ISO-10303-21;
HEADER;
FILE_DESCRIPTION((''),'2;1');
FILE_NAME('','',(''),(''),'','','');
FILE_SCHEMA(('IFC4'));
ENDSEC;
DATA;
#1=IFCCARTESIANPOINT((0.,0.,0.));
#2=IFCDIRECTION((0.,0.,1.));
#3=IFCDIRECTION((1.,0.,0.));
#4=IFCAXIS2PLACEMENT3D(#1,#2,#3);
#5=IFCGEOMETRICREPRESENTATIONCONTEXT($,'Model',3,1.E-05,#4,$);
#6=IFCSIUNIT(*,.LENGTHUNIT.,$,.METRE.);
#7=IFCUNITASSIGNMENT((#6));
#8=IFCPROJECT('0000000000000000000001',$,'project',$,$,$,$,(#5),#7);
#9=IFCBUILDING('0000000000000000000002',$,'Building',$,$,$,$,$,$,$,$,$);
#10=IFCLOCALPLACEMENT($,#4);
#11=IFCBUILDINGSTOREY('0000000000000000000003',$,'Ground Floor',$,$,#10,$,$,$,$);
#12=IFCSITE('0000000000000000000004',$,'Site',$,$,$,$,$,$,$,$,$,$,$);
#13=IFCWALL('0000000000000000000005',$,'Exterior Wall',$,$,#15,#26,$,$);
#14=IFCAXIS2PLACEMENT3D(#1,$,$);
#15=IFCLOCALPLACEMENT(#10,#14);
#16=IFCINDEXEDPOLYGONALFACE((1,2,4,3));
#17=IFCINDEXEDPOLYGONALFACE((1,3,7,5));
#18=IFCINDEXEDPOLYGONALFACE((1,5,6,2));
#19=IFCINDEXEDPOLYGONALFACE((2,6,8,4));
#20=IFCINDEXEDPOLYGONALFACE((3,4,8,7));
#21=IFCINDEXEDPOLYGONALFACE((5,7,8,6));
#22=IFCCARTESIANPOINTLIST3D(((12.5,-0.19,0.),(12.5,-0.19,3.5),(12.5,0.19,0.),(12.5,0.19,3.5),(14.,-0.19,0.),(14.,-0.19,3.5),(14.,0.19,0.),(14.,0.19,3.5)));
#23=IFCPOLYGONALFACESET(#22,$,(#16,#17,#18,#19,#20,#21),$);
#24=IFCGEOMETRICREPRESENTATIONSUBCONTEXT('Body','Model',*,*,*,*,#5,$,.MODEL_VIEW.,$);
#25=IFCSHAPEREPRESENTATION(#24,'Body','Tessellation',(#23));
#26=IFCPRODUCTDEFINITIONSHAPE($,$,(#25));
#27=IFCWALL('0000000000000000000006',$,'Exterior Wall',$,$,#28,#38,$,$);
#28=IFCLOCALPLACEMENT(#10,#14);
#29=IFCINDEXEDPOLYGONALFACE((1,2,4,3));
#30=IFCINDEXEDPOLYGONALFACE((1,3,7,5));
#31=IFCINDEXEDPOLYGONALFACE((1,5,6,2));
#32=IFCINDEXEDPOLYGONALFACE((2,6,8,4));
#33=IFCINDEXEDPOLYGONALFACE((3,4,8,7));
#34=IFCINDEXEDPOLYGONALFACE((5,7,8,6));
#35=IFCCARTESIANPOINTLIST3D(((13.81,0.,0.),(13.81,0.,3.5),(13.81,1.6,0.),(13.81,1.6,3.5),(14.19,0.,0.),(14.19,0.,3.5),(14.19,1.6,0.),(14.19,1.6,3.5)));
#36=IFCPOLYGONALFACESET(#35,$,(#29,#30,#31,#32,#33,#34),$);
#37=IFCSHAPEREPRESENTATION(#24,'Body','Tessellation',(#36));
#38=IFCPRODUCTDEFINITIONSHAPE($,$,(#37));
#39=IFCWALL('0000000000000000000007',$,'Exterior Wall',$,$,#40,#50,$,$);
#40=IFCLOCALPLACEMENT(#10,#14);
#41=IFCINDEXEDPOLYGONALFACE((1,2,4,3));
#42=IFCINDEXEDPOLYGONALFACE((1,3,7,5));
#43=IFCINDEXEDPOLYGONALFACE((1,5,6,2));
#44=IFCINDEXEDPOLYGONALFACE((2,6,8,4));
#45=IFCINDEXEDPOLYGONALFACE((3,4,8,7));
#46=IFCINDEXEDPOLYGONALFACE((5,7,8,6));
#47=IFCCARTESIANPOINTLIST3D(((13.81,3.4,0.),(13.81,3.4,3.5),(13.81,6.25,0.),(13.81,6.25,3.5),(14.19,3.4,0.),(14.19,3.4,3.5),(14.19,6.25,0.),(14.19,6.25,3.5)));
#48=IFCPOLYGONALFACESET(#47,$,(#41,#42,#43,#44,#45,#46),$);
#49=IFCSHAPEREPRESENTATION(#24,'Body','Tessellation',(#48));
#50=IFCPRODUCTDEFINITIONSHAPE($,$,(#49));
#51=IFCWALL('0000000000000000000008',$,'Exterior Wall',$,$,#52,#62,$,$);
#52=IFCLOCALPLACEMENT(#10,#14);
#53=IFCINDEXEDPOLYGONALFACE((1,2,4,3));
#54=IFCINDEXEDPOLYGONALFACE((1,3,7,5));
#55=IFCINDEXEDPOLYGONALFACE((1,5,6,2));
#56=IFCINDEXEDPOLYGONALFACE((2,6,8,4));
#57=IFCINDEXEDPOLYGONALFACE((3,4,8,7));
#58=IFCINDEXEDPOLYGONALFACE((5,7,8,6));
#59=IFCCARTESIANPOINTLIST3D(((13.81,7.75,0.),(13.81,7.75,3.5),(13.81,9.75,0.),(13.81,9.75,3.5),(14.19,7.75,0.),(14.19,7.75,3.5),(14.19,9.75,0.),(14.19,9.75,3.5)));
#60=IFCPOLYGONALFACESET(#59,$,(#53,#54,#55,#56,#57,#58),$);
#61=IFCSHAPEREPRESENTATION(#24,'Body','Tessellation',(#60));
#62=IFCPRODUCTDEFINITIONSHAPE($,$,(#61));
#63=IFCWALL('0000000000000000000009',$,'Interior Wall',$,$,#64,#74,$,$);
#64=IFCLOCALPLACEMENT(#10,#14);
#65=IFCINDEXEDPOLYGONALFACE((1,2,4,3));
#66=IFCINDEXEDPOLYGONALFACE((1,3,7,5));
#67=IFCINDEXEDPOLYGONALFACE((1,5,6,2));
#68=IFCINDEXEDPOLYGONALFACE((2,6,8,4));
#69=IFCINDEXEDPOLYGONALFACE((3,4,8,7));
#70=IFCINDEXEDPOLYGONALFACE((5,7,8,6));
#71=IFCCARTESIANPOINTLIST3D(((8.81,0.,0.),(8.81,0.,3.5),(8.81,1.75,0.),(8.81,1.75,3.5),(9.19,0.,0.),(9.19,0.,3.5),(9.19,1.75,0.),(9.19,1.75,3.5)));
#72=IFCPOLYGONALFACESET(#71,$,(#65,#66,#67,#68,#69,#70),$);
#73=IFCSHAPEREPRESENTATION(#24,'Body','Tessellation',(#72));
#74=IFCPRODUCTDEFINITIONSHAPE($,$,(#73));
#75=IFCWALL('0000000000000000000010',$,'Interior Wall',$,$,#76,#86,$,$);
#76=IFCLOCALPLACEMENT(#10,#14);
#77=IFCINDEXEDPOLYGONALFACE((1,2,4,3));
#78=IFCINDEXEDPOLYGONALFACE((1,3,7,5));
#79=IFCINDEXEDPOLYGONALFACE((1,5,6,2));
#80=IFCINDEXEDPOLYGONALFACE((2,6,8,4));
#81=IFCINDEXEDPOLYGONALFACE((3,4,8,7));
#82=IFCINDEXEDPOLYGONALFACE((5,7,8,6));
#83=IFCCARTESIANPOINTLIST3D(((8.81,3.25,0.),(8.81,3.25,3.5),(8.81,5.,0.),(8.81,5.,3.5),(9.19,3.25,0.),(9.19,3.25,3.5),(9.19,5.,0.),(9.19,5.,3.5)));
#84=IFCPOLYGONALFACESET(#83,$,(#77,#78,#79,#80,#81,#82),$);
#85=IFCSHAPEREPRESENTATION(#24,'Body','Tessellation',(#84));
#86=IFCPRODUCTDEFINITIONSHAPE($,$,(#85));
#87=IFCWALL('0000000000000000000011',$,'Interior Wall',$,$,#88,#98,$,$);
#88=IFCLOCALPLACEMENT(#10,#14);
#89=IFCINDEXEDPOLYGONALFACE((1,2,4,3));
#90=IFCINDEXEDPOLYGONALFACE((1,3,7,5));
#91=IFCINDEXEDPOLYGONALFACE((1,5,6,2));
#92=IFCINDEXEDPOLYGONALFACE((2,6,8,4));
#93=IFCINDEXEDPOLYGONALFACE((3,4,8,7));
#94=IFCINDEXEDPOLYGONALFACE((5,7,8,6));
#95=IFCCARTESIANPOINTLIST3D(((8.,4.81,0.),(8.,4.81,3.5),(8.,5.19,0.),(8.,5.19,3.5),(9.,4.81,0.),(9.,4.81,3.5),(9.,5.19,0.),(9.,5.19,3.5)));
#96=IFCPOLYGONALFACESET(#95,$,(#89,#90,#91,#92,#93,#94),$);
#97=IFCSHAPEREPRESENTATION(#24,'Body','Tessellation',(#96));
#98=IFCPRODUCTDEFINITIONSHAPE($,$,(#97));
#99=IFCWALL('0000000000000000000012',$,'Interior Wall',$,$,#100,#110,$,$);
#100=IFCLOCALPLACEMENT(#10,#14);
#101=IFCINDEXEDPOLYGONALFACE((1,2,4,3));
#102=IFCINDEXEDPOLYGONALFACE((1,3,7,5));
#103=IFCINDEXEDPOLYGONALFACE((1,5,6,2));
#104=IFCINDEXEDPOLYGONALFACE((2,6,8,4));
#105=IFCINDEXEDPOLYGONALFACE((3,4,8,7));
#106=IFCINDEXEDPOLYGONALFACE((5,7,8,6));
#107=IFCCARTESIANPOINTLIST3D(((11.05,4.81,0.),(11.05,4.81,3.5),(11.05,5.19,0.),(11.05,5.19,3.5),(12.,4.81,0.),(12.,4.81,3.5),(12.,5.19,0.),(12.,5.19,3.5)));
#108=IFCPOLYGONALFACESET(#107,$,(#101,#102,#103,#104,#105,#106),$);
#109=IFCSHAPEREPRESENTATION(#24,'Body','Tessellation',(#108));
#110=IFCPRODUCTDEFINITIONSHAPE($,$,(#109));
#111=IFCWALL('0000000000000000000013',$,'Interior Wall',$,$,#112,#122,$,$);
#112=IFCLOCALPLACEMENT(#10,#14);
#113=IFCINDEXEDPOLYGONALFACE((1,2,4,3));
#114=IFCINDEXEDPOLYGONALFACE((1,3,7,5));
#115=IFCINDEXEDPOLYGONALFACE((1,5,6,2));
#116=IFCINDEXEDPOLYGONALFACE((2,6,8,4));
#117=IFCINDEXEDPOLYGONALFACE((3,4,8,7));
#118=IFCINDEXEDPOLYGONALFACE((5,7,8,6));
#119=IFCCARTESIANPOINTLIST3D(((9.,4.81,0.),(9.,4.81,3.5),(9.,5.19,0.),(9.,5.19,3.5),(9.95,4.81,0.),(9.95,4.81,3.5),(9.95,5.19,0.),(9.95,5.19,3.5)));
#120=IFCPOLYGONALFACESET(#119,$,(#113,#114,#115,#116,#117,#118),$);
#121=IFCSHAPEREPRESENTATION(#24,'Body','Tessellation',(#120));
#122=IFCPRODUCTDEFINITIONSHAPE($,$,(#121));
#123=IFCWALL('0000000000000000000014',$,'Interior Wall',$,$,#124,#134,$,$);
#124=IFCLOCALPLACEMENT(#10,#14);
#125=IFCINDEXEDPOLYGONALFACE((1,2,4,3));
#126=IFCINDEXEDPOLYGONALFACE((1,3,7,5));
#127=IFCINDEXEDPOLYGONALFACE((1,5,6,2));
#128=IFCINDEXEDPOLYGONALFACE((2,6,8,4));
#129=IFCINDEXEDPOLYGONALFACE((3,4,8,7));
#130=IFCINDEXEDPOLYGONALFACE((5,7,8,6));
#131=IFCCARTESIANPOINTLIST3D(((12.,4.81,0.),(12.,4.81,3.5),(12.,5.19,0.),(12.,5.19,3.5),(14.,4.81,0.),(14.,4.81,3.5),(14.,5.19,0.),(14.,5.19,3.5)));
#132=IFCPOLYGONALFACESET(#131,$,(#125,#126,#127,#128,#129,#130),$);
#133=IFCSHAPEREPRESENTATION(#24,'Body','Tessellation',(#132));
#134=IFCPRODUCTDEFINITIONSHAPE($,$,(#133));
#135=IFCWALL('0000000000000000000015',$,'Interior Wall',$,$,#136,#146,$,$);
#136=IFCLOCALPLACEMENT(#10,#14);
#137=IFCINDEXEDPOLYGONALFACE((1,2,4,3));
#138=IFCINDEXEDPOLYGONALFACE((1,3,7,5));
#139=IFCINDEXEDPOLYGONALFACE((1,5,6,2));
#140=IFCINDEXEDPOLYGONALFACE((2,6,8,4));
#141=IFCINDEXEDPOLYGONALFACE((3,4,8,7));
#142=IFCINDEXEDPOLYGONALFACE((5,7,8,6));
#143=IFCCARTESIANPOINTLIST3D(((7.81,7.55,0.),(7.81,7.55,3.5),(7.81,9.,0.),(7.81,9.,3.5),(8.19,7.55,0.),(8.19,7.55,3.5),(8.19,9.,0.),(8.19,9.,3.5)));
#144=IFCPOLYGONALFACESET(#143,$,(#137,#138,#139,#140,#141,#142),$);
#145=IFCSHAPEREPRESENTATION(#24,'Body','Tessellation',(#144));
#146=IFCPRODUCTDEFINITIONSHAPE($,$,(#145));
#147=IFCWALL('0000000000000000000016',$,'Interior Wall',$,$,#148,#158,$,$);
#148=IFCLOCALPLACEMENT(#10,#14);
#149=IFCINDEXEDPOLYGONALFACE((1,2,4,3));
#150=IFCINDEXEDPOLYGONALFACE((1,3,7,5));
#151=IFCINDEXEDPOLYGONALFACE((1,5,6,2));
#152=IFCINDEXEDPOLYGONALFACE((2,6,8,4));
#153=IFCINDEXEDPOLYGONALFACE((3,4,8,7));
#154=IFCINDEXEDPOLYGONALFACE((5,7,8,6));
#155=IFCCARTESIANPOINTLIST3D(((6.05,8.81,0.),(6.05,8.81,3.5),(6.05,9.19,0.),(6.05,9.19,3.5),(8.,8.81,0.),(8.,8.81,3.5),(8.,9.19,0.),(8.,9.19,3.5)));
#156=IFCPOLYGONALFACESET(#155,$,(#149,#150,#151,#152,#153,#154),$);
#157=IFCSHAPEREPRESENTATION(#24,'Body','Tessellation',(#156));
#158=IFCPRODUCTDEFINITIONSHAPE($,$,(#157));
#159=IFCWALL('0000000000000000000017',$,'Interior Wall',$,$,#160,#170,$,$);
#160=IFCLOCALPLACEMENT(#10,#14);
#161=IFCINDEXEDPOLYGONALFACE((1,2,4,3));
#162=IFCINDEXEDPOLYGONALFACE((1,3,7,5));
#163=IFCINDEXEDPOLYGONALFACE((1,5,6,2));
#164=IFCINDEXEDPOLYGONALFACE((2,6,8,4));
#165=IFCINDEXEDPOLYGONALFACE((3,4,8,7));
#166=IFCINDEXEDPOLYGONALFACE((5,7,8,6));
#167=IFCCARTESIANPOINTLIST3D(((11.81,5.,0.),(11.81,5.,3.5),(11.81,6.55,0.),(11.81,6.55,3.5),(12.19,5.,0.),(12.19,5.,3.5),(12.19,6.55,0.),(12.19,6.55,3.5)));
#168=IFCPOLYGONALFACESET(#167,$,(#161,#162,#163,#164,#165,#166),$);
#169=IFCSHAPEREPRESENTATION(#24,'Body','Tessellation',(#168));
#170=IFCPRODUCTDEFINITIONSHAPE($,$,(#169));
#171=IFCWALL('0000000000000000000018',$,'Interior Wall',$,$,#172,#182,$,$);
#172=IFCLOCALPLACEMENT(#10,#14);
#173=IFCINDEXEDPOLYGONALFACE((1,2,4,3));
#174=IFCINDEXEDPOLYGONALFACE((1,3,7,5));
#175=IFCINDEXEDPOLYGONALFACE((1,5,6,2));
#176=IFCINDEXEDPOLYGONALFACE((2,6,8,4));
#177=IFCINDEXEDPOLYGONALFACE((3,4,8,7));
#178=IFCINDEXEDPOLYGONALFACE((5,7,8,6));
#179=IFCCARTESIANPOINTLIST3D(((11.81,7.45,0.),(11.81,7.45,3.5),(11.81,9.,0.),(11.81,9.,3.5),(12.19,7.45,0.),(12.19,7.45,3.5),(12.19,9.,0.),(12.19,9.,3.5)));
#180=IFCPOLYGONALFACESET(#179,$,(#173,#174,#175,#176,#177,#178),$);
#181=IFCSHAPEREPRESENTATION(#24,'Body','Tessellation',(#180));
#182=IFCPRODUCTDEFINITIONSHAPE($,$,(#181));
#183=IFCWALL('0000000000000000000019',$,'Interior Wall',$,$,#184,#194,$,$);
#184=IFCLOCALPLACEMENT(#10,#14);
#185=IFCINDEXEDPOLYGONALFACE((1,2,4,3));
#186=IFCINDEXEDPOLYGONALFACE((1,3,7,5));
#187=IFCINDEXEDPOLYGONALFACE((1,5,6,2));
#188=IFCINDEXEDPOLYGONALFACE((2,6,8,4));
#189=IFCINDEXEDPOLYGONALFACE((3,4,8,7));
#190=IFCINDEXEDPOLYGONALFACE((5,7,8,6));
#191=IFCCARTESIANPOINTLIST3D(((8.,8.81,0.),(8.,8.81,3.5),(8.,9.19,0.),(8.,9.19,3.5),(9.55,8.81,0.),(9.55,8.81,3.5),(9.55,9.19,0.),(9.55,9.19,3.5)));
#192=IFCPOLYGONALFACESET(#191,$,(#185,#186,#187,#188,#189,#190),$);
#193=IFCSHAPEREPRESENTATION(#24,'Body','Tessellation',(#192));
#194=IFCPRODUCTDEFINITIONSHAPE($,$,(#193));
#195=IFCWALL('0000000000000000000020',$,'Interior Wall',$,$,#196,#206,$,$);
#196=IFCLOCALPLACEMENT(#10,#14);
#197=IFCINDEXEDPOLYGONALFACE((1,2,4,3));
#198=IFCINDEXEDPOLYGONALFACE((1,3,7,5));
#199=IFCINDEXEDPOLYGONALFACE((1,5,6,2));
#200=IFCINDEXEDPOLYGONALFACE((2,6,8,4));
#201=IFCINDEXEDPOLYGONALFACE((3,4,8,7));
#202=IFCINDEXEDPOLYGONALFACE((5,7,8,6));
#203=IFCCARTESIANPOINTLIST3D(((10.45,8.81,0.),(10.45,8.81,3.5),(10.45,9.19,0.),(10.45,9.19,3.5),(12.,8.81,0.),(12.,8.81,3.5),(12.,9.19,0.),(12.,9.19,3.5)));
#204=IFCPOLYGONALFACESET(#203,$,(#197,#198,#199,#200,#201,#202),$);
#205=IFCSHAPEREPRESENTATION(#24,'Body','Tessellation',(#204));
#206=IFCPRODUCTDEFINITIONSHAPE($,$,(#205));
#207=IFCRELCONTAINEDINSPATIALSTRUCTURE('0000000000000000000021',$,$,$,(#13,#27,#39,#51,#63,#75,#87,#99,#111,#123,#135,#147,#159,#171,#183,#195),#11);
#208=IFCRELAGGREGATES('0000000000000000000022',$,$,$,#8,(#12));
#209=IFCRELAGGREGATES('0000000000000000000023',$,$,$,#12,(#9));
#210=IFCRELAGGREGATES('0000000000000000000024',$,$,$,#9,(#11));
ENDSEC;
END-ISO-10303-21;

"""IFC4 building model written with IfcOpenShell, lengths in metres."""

from ifc_helpers import new_model, si_unit, frame, origin_with_axes, place, context, subcontext, project, spatial, indexed_curve, outline, extrude, element, save


model = new_model("IFC4")

# Units and contexts
model_context = context("Model", 3, precision=1e-05, world=origin_with_axes())
body_context = subcontext(model_context, "Body", "Model", "MODEL_VIEW")
ifc_project = project(units=[si_unit("LENGTHUNIT", "METRE")], contexts=[model_context])

# Site, building, storey
site = spatial("IfcSite", under=ifc_project, Name="Site")
building = spatial("IfcBuilding", under=site, Name="Building")
storey_placement = place(None, origin_with_axes())
storey = spatial("IfcBuildingStorey", under=building, at=storey_placement, Name="Ground Floor")

# Walls
wall_1_placement = place(storey_placement, frame((12.5, 0.0, 0.0), z_axis=(0.0, 0.0, 1.0), x_axis=(1.0, 0.0, 0.0)))
element("IfcWall", 1, at=wall_1_placement, inside=storey, Name="Exterior Wall", context=body_context, shape_type="SweptSolid", body=[
    extrude(outline(indexed_curve([(0.0, 0.0), (0.0, 0.38), (1.5, 0.38), (1.5, 0.0), (0.0, 0.0)], self_intersect=False)), frame((0.0, -0.19, 0.0), z_axis=(0.0, 0.0, 1.0), x_axis=(1.0, 0.0, 0.0)), (0.0, 0.0, 1.0), 3.5),
])
wall_2_placement = place(storey_placement, frame((14.0, 0.0, 0.0), z_axis=(0.0, 0.0, 1.0), x_axis=(0.0, 1.0, 0.0)))
element("IfcWall", 2, at=wall_2_placement, inside=storey, Name="Exterior Wall", context=body_context, shape_type="SweptSolid", body=[
    extrude(outline(indexed_curve([(0.0, 0.0), (0.0, 0.38), (1.6, 0.38), (1.6, 0.0), (0.0, 0.0)], self_intersect=False)), frame((0.0, -0.19, 0.0), z_axis=(0.0, 0.0, 1.0), x_axis=(1.0, 0.0, 0.0)), (0.0, 0.0, 1.0), 3.5),
])
wall_3_placement = place(storey_placement, frame((14.0, 3.4, 0.0), z_axis=(0.0, 0.0, 1.0), x_axis=(0.0, 1.0, 0.0)))
element("IfcWall", 3, at=wall_3_placement, inside=storey, Name="Exterior Wall", context=body_context, shape_type="SweptSolid", body=[
    extrude(outline(indexed_curve([(0.0, 0.0), (0.0, 0.38), (2.85, 0.38), (2.85, 0.0), (0.0, 0.0)], self_intersect=False)), frame((0.0, -0.19, 0.0), z_axis=(0.0, 0.0, 1.0), x_axis=(1.0, 0.0, 0.0)), (0.0, 0.0, 1.0), 3.5),
])
wall_4_placement = place(storey_placement, frame((14.0, 7.75, 0.0), z_axis=(0.0, 0.0, 1.0), x_axis=(0.0, 1.0, 0.0)))
element("IfcWall", 4, at=wall_4_placement, inside=storey, Name="Exterior Wall", context=body_context, shape_type="SweptSolid", body=[
    extrude(outline(indexed_curve([(0.0, 0.0), (0.0, 0.38), (2.0, 0.38), (2.0, 0.0), (0.0, 0.0)], self_intersect=False)), frame((0.0, -0.19, 0.0), z_axis=(0.0, 0.0, 1.0), x_axis=(1.0, 0.0, 0.0)), (0.0, 0.0, 1.0), 3.5),
])
for number, where, z_axis, x_axis, name in (
    (5, (9.0, 0.0, 0.0), (0.0, 0.0, 1.0), (0.0, 1.0, 0.0), "Interior Wall"),
    (6, (9.0, 3.25, 0.0), (0.0, 0.0, 1.0), (0.0, 1.0, 0.0), "Interior Wall"),
):
    element("IfcWall", number, at=place(storey_placement, frame(where, z_axis=z_axis, x_axis=x_axis)), inside=storey, Name=name, context=body_context, shape_type="SweptSolid", body=[
        extrude(outline(indexed_curve([(0.0, 0.0), (0.0, 0.38), (1.75, 0.38), (1.75, 0.0), (0.0, 0.0)], self_intersect=False)), frame((0.0, -0.19, 0.0), z_axis=(0.0, 0.0, 1.0), x_axis=(1.0, 0.0, 0.0)), (0.0, 0.0, 1.0), 3.5),
    ])
wall_5_placement = place(storey_placement, frame((9.0, 5.0, 0.0), z_axis=(0.0, 0.0, 1.0), x_axis=(-1.0, 0.0, 0.0)))
element("IfcWall", 7, at=wall_5_placement, inside=storey, Name="Interior Wall", context=body_context, shape_type="SweptSolid", body=[
    extrude(outline(indexed_curve([(0.0, 0.0), (0.0, 0.38), (1.0, 0.38), (1.0, 0.0), (0.0, 0.0)], self_intersect=False)), frame((0.0, -0.19, 0.0), z_axis=(0.0, 0.0, 1.0), x_axis=(1.0, 0.0, 0.0)), (0.0, 0.0, 1.0), 3.5),
])
for number, where, z_axis, x_axis, name in (
    (8, (12.0, 5.0, 0.0), (0.0, 0.0, 1.0), (-1.0, 0.0, 0.0), "Interior Wall"),
    (9, (9.95, 5.0, 0.0), (0.0, 0.0, 1.0), (-1.0, 0.0, 0.0), "Interior Wall"),
):
    element("IfcWall", number, at=place(storey_placement, frame(where, z_axis=z_axis, x_axis=x_axis)), inside=storey, Name=name, context=body_context, shape_type="SweptSolid", body=[
        extrude(outline(indexed_curve([(0.0, 0.0), (0.0, 0.38), (0.95, 0.38), (0.95, 0.0), (0.0, 0.0)], self_intersect=False)), frame((0.0, -0.19, 0.0), z_axis=(0.0, 0.0, 1.0), x_axis=(1.0, 0.0, 0.0)), (0.0, 0.0, 1.0), 3.5),
    ])
wall_6_placement = place(storey_placement, frame((14.0, 5.0, 0.0), z_axis=(0.0, 0.0, 1.0), x_axis=(-1.0, 0.0, 0.0)))
element("IfcWall", 10, at=wall_6_placement, inside=storey, Name="Interior Wall", context=body_context, shape_type="SweptSolid", body=[
    extrude(outline(indexed_curve([(0.0, 0.0), (0.0, 0.38), (2.0, 0.38), (2.0, 0.0), (0.0, 0.0)], self_intersect=False)), frame((0.0, -0.19, 0.0), z_axis=(0.0, 0.0, 1.0), x_axis=(1.0, 0.0, 0.0)), (0.0, 0.0, 1.0), 3.5),
])
wall_7_placement = place(storey_placement, frame((8.0, 7.55, 0.0), z_axis=(0.0, 0.0, 1.0), x_axis=(0.0, 1.0, 0.0)))
element("IfcWall", 11, at=wall_7_placement, inside=storey, Name="Interior Wall", context=body_context, shape_type="SweptSolid", body=[
    extrude(outline(indexed_curve([(0.0, 0.0), (0.0, 0.38), (1.45, 0.38), (1.45, 0.0), (0.0, 0.0)], self_intersect=False)), frame((0.0, -0.19, 0.0), z_axis=(0.0, 0.0, 1.0), x_axis=(1.0, 0.0, 0.0)), (0.0, 0.0, 1.0), 3.5),
])
wall_8_placement = place(storey_placement, frame((8.0, 9.0, 0.0), z_axis=(0.0, 0.0, 1.0), x_axis=(-1.0, 0.0, 0.0)))
element("IfcWall", 12, at=wall_8_placement, inside=storey, Name="Interior Wall", context=body_context, shape_type="SweptSolid", body=[
    extrude(outline(indexed_curve([(0.0, 0.0), (0.0, 0.38), (1.95, 0.38), (1.95, 0.0), (0.0, 0.0)], self_intersect=False)), frame((0.0, -0.19, 0.0), z_axis=(0.0, 0.0, 1.0), x_axis=(1.0, 0.0, 0.0)), (0.0, 0.0, 1.0), 3.5),
])
for number, where, z_axis, x_axis, name in (
    (13, (12.0, 5.0, 0.0), (0.0, 0.0, 1.0), (0.0, 1.0, 0.0), "Interior Wall"),
    (14, (12.0, 7.45, 0.0), (0.0, 0.0, 1.0), (0.0, 1.0, 0.0), "Interior Wall"),
):
    element("IfcWall", number, at=place(storey_placement, frame(where, z_axis=z_axis, x_axis=x_axis)), inside=storey, Name=name, context=body_context, shape_type="SweptSolid", body=[
        extrude(outline(indexed_curve([(0.0, 0.0), (0.0, 0.38), (1.55, 0.38), (1.55, 0.0), (0.0, 0.0)], self_intersect=False)), frame((0.0, -0.19, 0.0), z_axis=(0.0, 0.0, 1.0), x_axis=(1.0, 0.0, 0.0)), (0.0, 0.0, 1.0), 3.5),
    ])
for number, where, z_axis, x_axis, name in (
    (15, (9.55, 9.0, 0.0), (0.0, 0.0, 1.0), (-1.0, 0.0, 0.0), "Interior Wall"),
    (16, (12.0, 9.0, 0.0), (0.0, 0.0, 1.0), (-1.0, 0.0, 0.0), "Interior Wall"),
):
    element("IfcWall", number, at=place(storey_placement, frame(where, z_axis=z_axis, x_axis=x_axis)), inside=storey, Name=name, context=body_context, shape_type="SweptSolid", body=[
        extrude(outline(indexed_curve([(0.0, 0.0), (0.0, 0.38), (1.55, 0.38), (1.55, 0.0), (0.0, 0.0)], self_intersect=False)), frame((0.0, -0.19, 0.0), z_axis=(0.0, 0.0, 1.0), x_axis=(1.0, 0.0, 0.0)), (0.0, 0.0, 1.0), 3.5),
    ])

save(model, "model.ifc")
